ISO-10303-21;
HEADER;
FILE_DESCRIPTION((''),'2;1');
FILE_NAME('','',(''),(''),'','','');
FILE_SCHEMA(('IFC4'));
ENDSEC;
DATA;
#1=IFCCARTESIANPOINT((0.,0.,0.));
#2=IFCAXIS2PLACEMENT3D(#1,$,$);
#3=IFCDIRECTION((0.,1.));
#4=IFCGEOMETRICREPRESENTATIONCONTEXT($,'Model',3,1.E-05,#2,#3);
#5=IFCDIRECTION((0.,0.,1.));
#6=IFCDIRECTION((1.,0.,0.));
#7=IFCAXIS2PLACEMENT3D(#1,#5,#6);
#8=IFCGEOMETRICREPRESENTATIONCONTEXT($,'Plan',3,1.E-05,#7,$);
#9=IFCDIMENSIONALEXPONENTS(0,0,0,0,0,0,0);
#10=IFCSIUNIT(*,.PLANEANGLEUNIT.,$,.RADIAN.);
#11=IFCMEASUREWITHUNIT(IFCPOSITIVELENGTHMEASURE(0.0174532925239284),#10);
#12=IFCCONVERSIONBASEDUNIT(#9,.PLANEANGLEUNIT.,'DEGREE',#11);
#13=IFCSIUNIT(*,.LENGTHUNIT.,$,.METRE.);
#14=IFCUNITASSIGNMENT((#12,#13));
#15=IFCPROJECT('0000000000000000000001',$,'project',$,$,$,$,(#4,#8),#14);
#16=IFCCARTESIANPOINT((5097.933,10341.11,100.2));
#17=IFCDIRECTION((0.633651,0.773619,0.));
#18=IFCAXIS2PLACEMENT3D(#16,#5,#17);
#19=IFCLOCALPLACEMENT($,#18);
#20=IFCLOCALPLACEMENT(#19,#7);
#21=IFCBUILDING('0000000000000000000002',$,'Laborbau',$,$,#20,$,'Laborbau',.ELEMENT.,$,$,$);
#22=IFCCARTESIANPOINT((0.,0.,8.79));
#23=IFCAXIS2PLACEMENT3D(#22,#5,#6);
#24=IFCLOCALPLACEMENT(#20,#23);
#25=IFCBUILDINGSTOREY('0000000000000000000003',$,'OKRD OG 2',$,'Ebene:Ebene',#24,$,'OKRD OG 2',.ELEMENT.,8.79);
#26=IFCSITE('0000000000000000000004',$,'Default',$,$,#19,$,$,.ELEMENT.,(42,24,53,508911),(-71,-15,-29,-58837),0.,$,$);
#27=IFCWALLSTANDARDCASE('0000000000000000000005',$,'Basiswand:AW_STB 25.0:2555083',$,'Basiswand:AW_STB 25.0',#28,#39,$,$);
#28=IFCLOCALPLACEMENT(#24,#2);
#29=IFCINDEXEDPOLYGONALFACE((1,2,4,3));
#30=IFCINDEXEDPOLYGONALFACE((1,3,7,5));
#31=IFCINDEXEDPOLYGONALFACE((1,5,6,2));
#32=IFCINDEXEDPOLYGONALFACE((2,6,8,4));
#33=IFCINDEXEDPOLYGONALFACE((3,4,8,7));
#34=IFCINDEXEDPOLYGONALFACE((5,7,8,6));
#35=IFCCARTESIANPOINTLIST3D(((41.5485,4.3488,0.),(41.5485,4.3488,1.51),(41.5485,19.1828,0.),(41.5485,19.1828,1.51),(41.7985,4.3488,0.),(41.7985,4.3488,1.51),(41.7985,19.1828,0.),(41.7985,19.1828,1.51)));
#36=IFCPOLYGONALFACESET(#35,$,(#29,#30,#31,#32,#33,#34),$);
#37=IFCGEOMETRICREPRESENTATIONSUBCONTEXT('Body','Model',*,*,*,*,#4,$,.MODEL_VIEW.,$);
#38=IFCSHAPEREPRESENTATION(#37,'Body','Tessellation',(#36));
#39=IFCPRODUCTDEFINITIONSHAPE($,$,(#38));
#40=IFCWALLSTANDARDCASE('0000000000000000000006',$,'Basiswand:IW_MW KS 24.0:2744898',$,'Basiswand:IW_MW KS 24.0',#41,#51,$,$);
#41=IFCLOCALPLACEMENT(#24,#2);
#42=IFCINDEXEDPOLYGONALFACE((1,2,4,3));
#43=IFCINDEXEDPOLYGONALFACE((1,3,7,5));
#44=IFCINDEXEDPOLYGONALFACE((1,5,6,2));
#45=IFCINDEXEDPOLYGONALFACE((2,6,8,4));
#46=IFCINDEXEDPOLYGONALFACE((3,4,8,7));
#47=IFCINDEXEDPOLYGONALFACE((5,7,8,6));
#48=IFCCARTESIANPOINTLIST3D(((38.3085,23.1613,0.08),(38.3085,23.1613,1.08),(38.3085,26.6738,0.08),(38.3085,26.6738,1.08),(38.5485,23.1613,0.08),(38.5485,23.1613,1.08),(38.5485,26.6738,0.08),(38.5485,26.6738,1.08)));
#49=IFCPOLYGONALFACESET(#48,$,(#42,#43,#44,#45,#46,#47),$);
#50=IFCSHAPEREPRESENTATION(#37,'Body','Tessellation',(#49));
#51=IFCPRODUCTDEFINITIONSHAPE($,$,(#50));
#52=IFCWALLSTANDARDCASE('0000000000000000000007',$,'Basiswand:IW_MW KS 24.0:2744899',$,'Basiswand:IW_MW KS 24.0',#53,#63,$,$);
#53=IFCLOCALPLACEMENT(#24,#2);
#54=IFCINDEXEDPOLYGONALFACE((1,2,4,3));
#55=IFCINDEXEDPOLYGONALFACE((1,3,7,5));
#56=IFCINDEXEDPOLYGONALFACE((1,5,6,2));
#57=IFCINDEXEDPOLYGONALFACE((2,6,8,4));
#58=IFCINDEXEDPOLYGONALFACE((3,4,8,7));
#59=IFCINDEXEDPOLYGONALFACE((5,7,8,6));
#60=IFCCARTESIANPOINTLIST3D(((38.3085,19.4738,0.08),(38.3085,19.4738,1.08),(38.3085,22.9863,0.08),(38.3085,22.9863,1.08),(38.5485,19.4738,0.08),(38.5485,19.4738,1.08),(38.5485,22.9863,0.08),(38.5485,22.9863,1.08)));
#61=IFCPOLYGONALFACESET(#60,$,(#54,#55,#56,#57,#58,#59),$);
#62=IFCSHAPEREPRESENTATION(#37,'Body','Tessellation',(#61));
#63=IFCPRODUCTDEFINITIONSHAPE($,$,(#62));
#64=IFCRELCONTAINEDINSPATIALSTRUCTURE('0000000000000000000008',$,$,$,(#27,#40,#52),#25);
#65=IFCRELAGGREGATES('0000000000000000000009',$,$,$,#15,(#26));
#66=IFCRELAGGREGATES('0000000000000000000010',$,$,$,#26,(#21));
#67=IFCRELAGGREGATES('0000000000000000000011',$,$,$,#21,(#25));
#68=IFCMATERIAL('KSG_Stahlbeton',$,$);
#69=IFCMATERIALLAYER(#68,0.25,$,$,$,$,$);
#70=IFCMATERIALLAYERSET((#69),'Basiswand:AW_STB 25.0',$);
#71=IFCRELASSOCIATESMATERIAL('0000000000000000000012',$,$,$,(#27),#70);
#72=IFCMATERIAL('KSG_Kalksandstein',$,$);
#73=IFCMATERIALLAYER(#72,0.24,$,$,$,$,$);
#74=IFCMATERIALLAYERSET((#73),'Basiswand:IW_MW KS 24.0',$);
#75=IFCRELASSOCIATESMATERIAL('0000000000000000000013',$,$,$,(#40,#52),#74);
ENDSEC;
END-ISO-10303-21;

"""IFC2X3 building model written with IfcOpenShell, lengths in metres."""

from ifc_helpers import new_model, entity, si_unit, converted_unit, direction, frame, frame_2d, origin, origin_with_axes, place, context, subcontext, project, spatial, rectangle, extrude, material, layer, layer_set, layer_usage, element, save


model = new_model("IFC2X3")

# Units and contexts
model_context = context("Model", 3, precision=1e-05, world=origin(), true_north=direction((0.0, 1.0)))
plan_context = context("Plan", 3, precision=1e-05, world=origin_with_axes())
body_context = subcontext(model_context, "Body", "Model", "MODEL_VIEW")
ifc_project = project(units=[converted_unit("PLANEANGLEUNIT", "DEGREE", entity("IfcPositiveLengthMeasure", 0.0174532925239284), si_unit("PLANEANGLEUNIT", "RADIAN"), dimensions=[0, 0, 0, 0, 0, 0, 0]), si_unit("LENGTHUNIT", "METRE")], contexts=[model_context, plan_context])

# Site, building, storey
site_placement = place(None, frame((5097.933, 10341.11, 100.2), z_axis=(0.0, 0.0, 1.0), x_axis=(0.633651, 0.773619, 0.0)))
site = spatial("IfcSite", under=ifc_project, at=site_placement, Name="Default", CompositionType="ELEMENT", RefLatitude=(42, 24, 53, 508911), RefLongitude=(-71, -15, -29, -58837), RefElevation=0.0)
building_placement = place(site_placement, origin_with_axes())
building = spatial("IfcBuilding", under=site, at=building_placement, Name="Laborbau", LongName="Laborbau", CompositionType="ELEMENT")
storey_placement = place(building_placement, frame((0.0, 0.0, 8.79), z_axis=(0.0, 0.0, 1.0), x_axis=(1.0, 0.0, 0.0)))
storey = spatial("IfcBuildingStorey", under=building, at=storey_placement, Name="OKRD OG 2", ObjectType="Ebene:Ebene", LongName="OKRD OG 2", CompositionType="ELEMENT", Elevation=8.79)

# Shared definitions
ifc_material_1 = material(Name="KSG_Kalksandstein")
ifc_material_2 = material(Name="KSG_Stahlbeton")

# Shared definitions
ifc_layer_1 = layer(ifc_material_1, 0.24)
ifc_layer_set_1 = layer_set([ifc_layer_1], Name="Basiswand:IW_MW KS 24.0")

# Walls
ifc_layer_2 = layer(ifc_material_2, 0.25)
ifc_layer_set_2 = layer_set([ifc_layer_2], Name="Basiswand:AW_STB 25.0")
ifc_layer_usage_1 = layer_usage(ifc_layer_set_2, "AXIS2", "NEGATIVE", 0.125)
wall_1_placement = place(storey_placement, frame((41.6735, 19.1828, 0.0), z_axis=(0.0, 0.0, 1.0), x_axis=(0.0, -1.0, 0.0)))
element("IfcWallStandardCase", 1, at=wall_1_placement, inside=storey, material=ifc_layer_usage_1, Name="Basiswand:AW_STB 25.0:2555083", ObjectType="Basiswand:AW_STB 25.0", context=body_context, shape_type="SweptSolid", body=[
    extrude(rectangle(XDim=14.834, YDim=0.25, at=frame_2d((7.417, 0.0), x_axis=(-1.0, 0.0))), origin(), (0.0, 0.0, 1.0), 1.51),
])
ifc_layer_usage_2 = layer_usage(ifc_layer_set_1, "AXIS2", "NEGATIVE", 0.12)
wall_2_placement = place(storey_placement, frame((38.4285, 26.6738, 0.08), z_axis=(0.0, 0.0, 1.0), x_axis=(0.0, -1.0, 0.0)))
element("IfcWallStandardCase", 2, at=wall_2_placement, inside=storey, material=ifc_layer_usage_2, Name="Basiswand:IW_MW KS 24.0:2744898", ObjectType="Basiswand:IW_MW KS 24.0", context=body_context, shape_type="SweptSolid", body=[
    extrude(rectangle(XDim=3.5125, YDim=0.24, at=frame_2d((1.7562, 0.0), x_axis=(-1.0, 0.0))), origin(), (0.0, 0.0, 1.0), 1.0),
])
ifc_layer_usage_3 = layer_usage(ifc_layer_set_1, "AXIS2", "NEGATIVE", 0.12)
wall_3_placement = place(storey_placement, frame((38.4285, 22.9863, 0.08), z_axis=(0.0, 0.0, 1.0), x_axis=(0.0, -1.0, 0.0)))
element("IfcWallStandardCase", 3, at=wall_3_placement, inside=storey, material=ifc_layer_usage_3, Name="Basiswand:IW_MW KS 24.0:2744899", ObjectType="Basiswand:IW_MW KS 24.0", context=body_context, shape_type="SweptSolid", body=[
    extrude(rectangle(XDim=3.5125, YDim=0.24, at=frame_2d((1.7562, 0.0), x_axis=(-1.0, 0.0))), origin(), (0.0, 0.0, 1.0), 1.0),
])

save(model, "model.ifc")
